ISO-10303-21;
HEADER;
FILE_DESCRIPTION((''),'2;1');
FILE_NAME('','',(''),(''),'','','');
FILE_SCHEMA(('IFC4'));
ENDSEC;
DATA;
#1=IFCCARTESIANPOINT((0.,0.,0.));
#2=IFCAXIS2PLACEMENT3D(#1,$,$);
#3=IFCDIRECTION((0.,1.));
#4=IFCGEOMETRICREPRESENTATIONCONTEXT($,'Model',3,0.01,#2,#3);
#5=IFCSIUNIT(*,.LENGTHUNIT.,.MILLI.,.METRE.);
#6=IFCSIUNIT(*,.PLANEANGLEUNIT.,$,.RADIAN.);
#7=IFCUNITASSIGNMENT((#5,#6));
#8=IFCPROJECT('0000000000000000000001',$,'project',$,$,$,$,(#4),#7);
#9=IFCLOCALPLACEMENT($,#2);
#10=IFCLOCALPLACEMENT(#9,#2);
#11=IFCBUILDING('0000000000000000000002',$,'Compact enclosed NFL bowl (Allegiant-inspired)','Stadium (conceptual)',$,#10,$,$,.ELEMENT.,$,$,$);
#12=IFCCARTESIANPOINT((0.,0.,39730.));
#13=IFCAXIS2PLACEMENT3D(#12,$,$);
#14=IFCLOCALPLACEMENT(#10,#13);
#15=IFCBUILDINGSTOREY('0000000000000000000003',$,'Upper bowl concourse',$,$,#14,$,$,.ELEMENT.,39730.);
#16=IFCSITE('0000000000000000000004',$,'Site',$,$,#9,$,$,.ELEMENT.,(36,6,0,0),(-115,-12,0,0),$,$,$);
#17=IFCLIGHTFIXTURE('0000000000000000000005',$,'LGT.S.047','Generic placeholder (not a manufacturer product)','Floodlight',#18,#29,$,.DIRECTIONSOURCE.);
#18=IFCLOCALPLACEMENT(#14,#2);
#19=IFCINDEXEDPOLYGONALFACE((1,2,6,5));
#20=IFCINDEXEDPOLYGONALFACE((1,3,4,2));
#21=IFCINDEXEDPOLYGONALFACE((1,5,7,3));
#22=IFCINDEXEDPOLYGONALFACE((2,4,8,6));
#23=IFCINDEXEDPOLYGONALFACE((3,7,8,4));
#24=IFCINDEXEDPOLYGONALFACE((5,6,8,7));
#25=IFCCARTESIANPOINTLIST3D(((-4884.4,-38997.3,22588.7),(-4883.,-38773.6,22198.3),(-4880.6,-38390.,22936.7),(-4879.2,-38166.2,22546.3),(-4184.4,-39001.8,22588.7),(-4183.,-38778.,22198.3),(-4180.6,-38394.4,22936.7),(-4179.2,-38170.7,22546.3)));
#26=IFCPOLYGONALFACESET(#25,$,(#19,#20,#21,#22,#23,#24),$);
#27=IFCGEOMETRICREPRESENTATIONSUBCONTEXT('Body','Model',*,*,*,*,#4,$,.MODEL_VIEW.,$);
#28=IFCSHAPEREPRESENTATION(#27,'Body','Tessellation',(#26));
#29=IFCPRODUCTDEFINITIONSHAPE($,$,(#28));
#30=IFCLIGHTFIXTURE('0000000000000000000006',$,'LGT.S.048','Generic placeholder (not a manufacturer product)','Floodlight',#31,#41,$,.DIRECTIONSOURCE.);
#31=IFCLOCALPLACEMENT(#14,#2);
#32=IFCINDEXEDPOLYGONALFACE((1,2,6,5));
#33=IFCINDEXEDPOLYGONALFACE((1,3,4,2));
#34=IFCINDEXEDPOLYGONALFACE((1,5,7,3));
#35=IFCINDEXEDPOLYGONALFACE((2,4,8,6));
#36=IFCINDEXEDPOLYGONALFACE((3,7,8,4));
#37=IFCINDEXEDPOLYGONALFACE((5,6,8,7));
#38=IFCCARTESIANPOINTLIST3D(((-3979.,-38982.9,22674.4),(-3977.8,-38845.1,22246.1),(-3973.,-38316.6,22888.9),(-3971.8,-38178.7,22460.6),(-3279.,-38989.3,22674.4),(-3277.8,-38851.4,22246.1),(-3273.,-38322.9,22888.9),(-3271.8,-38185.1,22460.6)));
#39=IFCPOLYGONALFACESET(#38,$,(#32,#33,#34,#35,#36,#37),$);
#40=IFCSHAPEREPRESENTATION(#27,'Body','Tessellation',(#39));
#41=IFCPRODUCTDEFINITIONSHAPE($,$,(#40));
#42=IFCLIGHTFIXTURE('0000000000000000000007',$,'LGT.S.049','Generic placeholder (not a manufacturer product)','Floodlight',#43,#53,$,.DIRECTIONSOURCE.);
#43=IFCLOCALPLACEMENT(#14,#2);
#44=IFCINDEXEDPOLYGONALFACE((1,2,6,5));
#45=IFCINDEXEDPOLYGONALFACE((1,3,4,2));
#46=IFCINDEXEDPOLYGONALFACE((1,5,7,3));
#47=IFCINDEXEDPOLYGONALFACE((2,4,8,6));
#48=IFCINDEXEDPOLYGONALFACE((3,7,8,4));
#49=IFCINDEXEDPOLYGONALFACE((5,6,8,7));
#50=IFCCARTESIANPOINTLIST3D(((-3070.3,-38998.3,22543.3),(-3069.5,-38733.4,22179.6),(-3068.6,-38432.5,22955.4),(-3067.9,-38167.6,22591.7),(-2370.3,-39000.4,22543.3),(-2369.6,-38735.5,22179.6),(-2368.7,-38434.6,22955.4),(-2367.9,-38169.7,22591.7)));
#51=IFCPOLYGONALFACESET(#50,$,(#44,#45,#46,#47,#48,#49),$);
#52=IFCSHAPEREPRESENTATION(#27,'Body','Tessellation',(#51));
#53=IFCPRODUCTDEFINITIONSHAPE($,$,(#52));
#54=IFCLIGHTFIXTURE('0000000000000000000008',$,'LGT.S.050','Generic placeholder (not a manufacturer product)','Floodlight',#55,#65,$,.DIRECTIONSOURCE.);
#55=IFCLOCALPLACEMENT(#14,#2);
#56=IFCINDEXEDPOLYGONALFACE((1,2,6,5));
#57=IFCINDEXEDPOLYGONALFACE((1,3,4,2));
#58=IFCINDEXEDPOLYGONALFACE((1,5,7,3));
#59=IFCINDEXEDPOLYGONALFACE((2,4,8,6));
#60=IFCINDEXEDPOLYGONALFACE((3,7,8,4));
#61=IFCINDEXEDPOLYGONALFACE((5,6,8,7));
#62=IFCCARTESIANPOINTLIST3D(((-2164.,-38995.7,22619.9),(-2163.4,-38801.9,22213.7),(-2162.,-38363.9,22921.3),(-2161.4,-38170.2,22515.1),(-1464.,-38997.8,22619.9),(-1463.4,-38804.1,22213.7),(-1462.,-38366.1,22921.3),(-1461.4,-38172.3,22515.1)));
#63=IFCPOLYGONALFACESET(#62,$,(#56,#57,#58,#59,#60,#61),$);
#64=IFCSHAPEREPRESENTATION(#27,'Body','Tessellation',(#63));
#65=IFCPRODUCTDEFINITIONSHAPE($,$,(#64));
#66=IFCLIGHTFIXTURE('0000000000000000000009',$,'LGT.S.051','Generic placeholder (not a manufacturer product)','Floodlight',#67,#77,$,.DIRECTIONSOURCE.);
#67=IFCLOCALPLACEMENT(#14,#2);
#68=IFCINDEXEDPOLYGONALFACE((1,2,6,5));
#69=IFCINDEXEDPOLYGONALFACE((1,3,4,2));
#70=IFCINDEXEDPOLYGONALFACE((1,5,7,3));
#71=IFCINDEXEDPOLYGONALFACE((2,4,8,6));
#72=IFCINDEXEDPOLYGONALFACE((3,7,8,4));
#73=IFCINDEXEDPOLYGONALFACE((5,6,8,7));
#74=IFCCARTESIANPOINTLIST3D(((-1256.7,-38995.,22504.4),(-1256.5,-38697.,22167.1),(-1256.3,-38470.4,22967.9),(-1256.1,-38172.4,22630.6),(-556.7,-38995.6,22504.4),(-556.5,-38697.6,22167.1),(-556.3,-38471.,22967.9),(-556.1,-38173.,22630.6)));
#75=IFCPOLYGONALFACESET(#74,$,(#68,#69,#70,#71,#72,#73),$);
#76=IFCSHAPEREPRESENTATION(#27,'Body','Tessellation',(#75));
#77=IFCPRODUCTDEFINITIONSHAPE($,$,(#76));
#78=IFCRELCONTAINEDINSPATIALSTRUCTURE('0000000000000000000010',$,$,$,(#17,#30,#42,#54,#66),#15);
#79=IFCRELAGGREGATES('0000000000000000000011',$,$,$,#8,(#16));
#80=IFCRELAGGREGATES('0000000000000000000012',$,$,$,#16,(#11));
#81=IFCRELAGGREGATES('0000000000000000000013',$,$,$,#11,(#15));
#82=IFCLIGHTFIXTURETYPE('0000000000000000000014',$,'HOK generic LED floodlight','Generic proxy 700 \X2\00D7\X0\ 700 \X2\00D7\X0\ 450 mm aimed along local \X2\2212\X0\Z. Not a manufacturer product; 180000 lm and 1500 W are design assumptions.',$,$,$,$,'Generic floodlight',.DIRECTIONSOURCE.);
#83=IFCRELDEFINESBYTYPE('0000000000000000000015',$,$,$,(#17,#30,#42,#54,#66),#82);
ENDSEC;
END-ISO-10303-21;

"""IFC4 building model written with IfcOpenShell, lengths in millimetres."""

from ifc_helpers import new_model, si_unit, direction, frame, origin, place, context, subcontext, project, spatial, rectangle, extrude, source, transform, mapped, type_object, type_shapes, element, save


model = new_model("IFC4")

# Units and contexts
model_context = context("Model", 3, precision=0.01, world=origin(), true_north=direction((0.0, 1.0)))
body_context = subcontext(model_context, "Body", "Model", "MODEL_VIEW")
ifc_project = project(units=[si_unit("LENGTHUNIT", "METRE", prefix="MILLI"), si_unit("PLANEANGLEUNIT", "RADIAN")], contexts=[model_context])

# Site, building, storey
site_placement = place(None, origin())
site = spatial("IfcSite", under=ifc_project, at=site_placement, Name="Site", CompositionType="ELEMENT", RefLatitude=(36, 6, 0, 0), RefLongitude=(-115, -12, 0, 0))
building_placement = place(site_placement, origin())
building = spatial("IfcBuilding", under=site, at=building_placement, Name="Compact enclosed NFL bowl (Allegiant-inspired)", Description="Stadium (conceptual)", CompositionType="ELEMENT")
storey_placement = place(building_placement, frame((0.0, 0.0, 39730.0)))
storey = spatial("IfcBuildingStorey", under=building, at=storey_placement, Name="Upper bowl concourse", CompositionType="ELEMENT", Elevation=39730.0)

# Light fixtures
light_fixture_type = type_object("IfcLightFixtureType", Name="HOK generic LED floodlight", Description="Generic proxy 700 × 700 × 450 mm aimed along local −Z. Not a manufacturer product; 180000 lm and 1500 W are design assumptions.", ElementType="Generic floodlight", PredefinedType="DIRECTIONSOURCE")
shared_shape = source(origin(), body_context, "Body", "SweptSolid", [
    extrude(rectangle(XDim=700.0, YDim=700.0), frame((0.0, 0.0, -225.0)), (0.0, 0.0, 1.0), 450.0),
])
type_shapes(light_fixture_type, [shared_shape])
for number, where, z_axis, x_axis, name in (
    (1, (-4531.8, -38584.0, 22567.5), (-0.003156, -0.497186, 0.867638), (0.99998, -0.006347, 0.0), "LGT.S.047"),
    (2, (-3625.4, -38584.0, 22567.5), (-0.00277, -0.306383, 0.951904), (0.999959, -0.00904, 0.0), "LGT.S.048"),
    (3, (-2719.1, -38584.0, 22567.5), (-0.001764, -0.588696, 0.808353), (0.999996, -0.002997, 0.0), "LGT.S.049"),
    (4, (-1812.7, -38584.0, 22567.5), (-0.001313, -0.430599, 0.902543), (0.999995, -0.003049, 0.0), "LGT.S.050"),
    (5, (-906.4, -38584.0, 22567.5), (-0.000545, -0.662104, 0.749412), (1.0, -0.000823, 0.0), "LGT.S.051"),
):
    element("IfcLightFixture", number, at=place(storey_placement, frame(where, z_axis=z_axis, x_axis=x_axis)), inside=storey, type_object=light_fixture_type, Name=name, Description="Generic placeholder (not a manufacturer product)", ObjectType="Floodlight", PredefinedType="DIRECTIONSOURCE", context=body_context, shape_type="MappedRepresentation", body=[
        mapped(shared_shape, transform((0.0, 0.0, 0.0))),
    ])

save(model, "model.ifc")
